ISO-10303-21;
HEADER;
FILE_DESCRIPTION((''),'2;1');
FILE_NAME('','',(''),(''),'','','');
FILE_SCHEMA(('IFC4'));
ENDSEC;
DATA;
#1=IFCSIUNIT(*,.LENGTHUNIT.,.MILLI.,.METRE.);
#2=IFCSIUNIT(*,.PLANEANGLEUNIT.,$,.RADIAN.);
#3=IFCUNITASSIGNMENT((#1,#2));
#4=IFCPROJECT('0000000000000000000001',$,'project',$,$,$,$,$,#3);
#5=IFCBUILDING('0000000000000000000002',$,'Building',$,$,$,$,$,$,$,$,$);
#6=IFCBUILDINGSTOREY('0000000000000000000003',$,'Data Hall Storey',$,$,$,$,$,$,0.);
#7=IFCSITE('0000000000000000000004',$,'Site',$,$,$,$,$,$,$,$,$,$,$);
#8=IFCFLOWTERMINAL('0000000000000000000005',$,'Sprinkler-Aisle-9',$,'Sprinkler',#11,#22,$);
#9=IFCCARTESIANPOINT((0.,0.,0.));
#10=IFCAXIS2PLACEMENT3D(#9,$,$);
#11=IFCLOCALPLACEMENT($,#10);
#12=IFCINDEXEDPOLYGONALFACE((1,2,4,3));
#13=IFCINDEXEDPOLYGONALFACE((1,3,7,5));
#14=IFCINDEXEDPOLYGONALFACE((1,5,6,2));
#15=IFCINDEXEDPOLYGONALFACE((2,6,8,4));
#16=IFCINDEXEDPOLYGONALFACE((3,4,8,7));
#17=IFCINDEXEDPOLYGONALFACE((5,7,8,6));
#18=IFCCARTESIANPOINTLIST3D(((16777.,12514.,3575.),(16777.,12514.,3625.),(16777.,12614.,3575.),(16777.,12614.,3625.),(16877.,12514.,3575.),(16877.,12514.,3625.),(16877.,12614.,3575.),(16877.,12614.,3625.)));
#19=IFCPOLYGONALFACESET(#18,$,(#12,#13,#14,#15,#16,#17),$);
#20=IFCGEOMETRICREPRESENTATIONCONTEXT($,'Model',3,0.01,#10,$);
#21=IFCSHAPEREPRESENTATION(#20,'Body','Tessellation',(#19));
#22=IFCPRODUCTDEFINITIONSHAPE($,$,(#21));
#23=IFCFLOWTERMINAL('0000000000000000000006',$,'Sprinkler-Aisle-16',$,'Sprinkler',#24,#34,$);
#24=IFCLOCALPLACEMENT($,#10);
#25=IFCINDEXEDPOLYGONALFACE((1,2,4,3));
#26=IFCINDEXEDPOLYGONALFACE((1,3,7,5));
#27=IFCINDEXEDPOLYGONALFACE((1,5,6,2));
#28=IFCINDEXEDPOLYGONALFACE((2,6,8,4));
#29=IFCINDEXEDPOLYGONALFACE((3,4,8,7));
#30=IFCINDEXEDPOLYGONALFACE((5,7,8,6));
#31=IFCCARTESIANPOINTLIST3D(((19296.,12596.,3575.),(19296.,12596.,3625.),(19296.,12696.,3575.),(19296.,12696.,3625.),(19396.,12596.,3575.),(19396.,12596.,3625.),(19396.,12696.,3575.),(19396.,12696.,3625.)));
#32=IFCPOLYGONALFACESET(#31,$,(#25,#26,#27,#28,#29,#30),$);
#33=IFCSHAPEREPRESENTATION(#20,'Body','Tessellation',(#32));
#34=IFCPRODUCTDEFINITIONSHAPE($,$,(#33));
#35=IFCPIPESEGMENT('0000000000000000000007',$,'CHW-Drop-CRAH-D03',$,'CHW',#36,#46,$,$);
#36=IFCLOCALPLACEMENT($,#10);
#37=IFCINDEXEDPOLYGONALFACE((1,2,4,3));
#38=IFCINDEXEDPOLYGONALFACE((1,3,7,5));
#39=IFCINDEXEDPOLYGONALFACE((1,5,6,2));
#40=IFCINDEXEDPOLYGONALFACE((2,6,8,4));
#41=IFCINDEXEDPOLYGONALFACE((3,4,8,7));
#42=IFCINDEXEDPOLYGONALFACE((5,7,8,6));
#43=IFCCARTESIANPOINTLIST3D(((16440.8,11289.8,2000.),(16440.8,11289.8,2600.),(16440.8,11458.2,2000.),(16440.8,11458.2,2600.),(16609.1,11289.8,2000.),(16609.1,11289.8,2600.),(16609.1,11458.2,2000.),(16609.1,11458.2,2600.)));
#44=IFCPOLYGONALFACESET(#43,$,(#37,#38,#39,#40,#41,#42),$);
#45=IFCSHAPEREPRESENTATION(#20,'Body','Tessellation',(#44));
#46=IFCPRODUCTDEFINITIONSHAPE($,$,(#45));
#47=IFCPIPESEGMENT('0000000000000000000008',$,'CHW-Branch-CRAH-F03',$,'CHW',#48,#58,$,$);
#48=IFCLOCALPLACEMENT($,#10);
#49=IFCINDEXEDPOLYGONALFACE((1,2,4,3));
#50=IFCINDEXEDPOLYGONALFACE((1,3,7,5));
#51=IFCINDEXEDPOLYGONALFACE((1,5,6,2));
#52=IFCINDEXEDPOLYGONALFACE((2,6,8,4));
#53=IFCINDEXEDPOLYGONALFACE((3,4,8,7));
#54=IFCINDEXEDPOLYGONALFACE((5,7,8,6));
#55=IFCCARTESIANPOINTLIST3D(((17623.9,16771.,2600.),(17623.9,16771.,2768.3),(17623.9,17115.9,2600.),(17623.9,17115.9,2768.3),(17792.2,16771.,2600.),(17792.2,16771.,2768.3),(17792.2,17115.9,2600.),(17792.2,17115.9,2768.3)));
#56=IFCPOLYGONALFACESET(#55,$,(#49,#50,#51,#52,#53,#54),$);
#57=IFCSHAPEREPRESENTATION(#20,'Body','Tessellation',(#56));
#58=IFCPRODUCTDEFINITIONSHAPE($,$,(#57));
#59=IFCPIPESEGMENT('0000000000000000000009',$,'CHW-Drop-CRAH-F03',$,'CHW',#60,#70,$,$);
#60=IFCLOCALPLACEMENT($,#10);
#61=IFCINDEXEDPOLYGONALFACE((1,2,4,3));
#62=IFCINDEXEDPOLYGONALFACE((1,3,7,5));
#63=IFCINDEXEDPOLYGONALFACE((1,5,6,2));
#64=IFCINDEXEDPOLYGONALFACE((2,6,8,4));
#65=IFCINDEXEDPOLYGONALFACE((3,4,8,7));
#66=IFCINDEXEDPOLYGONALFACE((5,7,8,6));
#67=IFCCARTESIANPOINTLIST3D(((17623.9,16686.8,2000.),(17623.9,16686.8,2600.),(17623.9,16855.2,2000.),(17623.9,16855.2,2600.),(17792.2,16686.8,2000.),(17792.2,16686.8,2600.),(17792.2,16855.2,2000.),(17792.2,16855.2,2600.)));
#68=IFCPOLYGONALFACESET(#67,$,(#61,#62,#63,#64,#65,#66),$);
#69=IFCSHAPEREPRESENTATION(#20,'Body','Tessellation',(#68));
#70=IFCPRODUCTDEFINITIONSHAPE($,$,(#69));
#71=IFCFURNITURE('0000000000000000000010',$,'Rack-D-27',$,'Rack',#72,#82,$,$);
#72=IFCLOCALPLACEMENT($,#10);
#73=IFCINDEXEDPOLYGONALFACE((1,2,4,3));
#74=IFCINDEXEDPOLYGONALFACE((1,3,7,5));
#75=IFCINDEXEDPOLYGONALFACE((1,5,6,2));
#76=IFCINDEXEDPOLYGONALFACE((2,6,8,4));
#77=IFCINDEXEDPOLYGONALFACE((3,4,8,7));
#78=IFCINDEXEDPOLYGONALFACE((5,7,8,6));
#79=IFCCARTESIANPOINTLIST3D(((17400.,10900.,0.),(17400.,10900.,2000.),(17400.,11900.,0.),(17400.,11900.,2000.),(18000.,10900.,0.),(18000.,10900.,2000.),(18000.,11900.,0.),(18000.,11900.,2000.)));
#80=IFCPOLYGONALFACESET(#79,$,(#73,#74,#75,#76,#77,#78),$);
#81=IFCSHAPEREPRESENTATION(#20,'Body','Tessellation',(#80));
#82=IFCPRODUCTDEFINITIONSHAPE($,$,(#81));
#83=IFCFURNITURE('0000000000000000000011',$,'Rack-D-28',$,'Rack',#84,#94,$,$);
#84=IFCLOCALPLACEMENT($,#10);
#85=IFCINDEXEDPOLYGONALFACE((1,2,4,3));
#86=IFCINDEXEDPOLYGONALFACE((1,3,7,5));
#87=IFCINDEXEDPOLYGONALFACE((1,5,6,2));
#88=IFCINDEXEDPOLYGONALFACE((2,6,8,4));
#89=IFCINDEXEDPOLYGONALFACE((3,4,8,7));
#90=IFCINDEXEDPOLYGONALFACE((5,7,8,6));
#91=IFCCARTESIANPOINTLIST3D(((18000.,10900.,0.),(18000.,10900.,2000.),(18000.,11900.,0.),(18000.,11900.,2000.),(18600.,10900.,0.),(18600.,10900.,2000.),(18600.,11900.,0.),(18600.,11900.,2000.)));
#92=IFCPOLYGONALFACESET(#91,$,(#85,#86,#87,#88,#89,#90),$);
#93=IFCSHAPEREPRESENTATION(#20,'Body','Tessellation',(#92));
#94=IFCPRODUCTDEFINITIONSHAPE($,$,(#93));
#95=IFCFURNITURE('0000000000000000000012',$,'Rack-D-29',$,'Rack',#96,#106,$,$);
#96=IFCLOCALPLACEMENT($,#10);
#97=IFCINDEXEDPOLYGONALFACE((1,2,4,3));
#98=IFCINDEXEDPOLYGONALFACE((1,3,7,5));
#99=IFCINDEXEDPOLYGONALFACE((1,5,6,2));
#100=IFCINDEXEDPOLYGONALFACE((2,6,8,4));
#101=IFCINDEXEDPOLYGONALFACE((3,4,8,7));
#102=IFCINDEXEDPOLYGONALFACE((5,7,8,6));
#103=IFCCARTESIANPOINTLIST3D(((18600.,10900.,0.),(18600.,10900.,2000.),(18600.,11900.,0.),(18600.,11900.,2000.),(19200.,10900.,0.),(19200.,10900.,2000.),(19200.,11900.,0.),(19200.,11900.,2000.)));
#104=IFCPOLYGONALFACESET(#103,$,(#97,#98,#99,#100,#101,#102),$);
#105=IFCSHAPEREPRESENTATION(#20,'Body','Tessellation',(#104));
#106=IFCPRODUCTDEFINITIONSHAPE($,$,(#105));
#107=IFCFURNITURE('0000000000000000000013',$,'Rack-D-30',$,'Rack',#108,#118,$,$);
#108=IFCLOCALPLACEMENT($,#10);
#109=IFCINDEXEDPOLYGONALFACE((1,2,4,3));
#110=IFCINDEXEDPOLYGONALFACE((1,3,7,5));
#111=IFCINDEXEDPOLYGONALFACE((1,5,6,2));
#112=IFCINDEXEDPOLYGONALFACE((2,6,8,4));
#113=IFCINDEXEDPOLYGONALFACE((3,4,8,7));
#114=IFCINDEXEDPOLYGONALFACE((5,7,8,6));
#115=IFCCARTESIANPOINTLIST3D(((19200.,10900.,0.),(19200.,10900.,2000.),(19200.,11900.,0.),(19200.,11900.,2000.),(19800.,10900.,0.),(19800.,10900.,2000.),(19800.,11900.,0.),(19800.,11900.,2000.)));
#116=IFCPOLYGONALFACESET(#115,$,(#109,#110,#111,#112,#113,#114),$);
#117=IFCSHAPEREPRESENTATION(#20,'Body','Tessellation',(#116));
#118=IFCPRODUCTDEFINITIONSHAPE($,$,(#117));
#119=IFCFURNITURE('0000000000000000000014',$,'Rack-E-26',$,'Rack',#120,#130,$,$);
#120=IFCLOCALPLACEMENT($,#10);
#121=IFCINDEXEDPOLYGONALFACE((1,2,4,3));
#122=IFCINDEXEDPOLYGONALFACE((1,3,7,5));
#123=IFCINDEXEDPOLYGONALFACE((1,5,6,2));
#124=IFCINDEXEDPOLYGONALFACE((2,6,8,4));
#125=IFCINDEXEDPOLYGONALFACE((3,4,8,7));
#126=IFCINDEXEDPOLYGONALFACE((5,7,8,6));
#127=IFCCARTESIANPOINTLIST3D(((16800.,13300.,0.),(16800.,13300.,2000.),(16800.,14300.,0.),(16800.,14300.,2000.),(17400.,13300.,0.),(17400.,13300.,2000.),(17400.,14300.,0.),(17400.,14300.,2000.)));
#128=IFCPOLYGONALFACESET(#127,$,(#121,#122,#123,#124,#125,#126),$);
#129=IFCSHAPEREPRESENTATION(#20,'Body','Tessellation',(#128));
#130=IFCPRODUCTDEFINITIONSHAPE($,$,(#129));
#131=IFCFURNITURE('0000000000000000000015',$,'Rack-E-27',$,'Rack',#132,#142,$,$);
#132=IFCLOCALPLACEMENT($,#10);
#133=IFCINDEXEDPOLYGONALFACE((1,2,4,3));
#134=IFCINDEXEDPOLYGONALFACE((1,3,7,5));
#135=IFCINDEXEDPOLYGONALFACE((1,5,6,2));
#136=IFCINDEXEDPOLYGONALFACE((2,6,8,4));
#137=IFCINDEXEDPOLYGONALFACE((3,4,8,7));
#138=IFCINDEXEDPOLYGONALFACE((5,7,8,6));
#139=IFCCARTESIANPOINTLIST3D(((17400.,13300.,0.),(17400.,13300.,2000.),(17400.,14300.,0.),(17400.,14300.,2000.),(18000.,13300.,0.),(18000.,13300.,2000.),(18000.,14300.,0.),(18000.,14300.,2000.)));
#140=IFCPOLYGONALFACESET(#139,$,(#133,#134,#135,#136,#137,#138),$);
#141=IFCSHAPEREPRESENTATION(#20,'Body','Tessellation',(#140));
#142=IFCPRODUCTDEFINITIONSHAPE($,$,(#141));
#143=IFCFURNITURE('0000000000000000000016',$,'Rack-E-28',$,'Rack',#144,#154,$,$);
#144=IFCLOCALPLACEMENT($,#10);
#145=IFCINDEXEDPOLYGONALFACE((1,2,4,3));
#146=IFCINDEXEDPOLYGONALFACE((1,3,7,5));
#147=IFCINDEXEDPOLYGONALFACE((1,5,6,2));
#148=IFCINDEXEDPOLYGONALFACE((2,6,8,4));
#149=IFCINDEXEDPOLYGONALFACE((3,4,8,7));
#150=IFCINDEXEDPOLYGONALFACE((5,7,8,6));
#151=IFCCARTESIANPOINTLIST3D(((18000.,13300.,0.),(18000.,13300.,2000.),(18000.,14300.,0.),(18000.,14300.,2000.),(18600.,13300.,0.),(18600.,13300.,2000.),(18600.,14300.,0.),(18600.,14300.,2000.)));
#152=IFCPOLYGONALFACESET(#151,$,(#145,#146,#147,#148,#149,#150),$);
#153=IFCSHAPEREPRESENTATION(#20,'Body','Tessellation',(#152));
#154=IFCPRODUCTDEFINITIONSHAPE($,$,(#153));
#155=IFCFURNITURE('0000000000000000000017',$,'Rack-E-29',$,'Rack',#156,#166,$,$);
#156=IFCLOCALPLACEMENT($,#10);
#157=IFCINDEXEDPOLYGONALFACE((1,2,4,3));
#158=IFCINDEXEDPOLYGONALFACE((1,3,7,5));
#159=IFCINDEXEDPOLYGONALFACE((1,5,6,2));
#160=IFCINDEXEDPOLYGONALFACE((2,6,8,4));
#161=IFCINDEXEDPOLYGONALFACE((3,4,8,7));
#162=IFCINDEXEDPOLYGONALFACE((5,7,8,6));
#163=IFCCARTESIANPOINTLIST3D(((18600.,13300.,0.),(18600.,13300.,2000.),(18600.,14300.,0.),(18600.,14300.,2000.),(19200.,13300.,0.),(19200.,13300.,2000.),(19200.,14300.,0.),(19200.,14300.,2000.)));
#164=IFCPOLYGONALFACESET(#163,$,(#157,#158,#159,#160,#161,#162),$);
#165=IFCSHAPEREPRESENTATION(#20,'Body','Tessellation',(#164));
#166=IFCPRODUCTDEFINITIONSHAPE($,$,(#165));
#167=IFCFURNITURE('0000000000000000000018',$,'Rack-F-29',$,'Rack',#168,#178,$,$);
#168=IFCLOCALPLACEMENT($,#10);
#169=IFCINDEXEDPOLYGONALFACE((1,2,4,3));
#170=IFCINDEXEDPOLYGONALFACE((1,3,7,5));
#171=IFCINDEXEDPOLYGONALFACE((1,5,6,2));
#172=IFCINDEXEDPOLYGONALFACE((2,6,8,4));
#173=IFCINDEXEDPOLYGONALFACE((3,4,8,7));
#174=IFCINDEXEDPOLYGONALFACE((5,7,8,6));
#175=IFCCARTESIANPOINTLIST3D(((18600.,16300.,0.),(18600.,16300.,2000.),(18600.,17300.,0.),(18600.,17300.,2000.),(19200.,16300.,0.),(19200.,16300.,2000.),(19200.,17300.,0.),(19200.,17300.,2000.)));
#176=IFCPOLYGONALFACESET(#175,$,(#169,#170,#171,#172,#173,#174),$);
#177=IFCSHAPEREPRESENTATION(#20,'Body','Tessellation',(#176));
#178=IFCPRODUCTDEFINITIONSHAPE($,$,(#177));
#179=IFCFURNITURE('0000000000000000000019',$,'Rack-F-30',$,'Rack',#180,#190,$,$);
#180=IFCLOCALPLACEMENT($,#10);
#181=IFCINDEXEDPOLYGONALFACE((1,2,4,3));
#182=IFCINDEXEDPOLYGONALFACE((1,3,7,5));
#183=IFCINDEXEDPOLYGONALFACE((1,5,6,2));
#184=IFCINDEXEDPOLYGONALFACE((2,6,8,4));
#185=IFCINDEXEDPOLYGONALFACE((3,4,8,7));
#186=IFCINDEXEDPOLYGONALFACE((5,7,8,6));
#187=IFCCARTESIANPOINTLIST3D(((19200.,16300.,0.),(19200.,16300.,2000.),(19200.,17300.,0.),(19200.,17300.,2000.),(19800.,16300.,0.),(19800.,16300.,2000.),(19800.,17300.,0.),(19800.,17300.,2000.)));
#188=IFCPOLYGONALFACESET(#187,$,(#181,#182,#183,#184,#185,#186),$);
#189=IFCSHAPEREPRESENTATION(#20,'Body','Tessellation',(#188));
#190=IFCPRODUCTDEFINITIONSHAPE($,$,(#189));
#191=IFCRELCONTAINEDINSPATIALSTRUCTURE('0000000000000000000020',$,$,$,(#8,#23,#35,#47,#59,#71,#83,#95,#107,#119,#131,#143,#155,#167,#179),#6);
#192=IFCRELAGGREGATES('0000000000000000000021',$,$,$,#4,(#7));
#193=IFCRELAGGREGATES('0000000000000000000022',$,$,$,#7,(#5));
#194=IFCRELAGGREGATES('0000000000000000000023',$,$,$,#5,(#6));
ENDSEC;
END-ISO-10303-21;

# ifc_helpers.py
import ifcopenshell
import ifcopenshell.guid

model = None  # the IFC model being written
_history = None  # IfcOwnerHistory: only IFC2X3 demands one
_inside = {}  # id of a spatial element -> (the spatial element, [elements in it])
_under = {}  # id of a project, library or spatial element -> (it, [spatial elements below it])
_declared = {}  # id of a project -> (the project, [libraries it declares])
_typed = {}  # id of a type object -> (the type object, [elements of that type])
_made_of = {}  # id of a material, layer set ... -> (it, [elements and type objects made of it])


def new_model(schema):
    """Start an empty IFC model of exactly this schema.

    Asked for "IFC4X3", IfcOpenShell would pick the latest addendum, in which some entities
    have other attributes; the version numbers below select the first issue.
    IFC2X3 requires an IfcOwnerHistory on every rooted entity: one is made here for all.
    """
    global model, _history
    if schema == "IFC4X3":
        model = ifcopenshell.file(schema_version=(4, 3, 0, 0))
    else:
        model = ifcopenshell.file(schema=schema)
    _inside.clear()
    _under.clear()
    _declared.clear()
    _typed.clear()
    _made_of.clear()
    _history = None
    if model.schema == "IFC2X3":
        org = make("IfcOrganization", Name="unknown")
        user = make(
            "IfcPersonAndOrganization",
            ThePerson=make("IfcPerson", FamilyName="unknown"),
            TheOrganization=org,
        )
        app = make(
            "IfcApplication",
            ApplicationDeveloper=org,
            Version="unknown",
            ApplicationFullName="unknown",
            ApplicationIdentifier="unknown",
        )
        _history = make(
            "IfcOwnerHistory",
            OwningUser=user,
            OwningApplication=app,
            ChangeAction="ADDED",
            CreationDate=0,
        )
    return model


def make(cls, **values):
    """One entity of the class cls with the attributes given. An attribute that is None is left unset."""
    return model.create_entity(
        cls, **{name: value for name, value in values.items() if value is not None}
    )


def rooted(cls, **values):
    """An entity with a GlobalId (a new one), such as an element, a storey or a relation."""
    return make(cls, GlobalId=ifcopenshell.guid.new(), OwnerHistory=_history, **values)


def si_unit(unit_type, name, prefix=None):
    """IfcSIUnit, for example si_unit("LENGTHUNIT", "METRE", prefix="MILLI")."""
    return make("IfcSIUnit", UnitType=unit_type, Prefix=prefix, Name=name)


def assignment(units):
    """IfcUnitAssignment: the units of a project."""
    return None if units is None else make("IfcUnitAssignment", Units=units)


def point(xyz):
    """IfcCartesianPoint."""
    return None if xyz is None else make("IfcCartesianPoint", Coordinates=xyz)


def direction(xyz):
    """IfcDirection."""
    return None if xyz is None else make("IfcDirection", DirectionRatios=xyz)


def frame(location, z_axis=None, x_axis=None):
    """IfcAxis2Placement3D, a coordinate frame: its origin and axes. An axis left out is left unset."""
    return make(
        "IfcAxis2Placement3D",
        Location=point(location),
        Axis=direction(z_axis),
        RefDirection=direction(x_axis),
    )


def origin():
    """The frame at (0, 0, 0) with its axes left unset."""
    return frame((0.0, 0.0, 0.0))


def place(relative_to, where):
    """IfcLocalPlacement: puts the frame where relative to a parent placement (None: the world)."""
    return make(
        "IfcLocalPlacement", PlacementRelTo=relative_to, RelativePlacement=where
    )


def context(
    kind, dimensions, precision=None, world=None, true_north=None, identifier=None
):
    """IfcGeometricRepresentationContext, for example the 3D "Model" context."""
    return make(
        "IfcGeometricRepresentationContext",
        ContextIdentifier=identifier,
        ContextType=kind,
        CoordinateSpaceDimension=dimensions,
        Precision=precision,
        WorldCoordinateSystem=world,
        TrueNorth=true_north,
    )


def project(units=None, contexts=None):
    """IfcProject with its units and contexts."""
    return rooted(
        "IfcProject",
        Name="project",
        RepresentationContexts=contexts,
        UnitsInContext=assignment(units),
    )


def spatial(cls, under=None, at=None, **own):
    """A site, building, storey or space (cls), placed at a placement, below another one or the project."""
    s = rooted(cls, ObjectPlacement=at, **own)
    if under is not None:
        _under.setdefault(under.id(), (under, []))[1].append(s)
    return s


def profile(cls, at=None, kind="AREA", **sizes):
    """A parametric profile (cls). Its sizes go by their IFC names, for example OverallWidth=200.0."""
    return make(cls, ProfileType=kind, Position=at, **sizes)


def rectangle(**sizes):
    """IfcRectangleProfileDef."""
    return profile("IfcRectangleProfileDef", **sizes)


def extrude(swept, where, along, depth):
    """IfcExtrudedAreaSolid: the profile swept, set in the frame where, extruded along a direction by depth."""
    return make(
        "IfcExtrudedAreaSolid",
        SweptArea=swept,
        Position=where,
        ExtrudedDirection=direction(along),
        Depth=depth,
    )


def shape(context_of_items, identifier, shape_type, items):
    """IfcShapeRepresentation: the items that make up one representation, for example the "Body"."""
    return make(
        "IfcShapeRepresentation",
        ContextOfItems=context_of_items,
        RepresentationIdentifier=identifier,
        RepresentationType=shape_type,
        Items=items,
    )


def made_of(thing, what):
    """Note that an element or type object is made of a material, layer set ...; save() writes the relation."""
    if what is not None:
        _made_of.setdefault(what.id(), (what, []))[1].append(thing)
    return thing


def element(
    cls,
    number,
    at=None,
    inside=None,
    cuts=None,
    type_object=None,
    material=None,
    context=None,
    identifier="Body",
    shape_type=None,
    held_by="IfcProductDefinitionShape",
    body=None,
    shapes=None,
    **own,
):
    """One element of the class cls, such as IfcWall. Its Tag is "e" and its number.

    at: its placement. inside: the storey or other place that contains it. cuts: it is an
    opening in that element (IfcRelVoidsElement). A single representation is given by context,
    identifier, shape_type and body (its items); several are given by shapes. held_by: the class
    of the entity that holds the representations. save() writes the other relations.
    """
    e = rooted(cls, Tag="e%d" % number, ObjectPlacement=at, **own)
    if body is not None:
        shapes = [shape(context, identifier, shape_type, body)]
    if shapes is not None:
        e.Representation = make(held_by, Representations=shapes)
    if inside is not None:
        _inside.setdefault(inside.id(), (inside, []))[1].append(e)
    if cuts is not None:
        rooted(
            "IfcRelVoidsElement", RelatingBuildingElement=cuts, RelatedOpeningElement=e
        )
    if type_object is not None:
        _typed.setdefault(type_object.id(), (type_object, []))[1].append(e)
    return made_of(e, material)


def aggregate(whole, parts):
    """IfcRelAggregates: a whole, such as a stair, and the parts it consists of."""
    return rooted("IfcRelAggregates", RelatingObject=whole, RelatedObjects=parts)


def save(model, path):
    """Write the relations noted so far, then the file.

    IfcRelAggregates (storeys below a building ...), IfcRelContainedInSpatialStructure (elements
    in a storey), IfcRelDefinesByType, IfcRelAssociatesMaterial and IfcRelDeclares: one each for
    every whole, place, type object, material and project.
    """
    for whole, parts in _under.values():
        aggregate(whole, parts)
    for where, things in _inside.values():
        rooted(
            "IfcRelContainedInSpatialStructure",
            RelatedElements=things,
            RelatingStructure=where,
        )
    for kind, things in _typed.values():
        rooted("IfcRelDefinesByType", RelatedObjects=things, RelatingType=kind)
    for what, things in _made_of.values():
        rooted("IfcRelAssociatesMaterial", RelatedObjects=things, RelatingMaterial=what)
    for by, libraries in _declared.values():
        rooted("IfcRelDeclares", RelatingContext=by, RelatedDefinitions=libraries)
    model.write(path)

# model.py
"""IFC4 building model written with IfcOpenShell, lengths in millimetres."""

from ifc_helpers import new_model, si_unit, frame, origin, place, context, project, spatial, rectangle, extrude, element, save


model = new_model("IFC4")

# Units and contexts
model_context = context("Model", 3, precision=0.01, world=origin())
ifc_project = project(units=[si_unit("LENGTHUNIT", "METRE", prefix="MILLI"), si_unit("PLANEANGLEUNIT", "RADIAN")])

# Site, building, storey
site = spatial("IfcSite", under=ifc_project, Name="Site")
building = spatial("IfcBuilding", under=site, Name="Building")
storey = spatial("IfcBuildingStorey", under=building, Name="Data Hall Storey", Elevation=0.0)

# Flow terminals
for number, where, name in (
    (1, (16827.0, 12564.0, 3575.0), "Sprinkler-Aisle-9"),
    (2, (19346.0, 12646.0, 3575.0), "Sprinkler-Aisle-16"),
):
    element("IfcFlowTerminal", number, at=place(None, frame(where)), inside=storey, Name=name, ObjectType="Sprinkler", context=model_context, shape_type="SweptSolid", body=[
        extrude(rectangle(XDim=100.0, YDim=100.0), origin(), (0.0, 0.0, 1.0), 50.0),
    ])

# Pipe segments
pipe_segment_1_placement = place(None, frame((16525.0, 11374.0, 2000.0)))
element("IfcPipeSegment", 3, at=pipe_segment_1_placement, inside=storey, Name="CHW-Drop-CRAH-D03", ObjectType="CHW", context=model_context, shape_type="SweptSolid", body=[
    extrude(rectangle(XDim=168.3, YDim=168.3), origin(), (0.0, 0.0, 1.0), 600.0),
])
pipe_segment_2_placement = place(None, frame((17708.0, 16943.4, 2600.0)))
element("IfcPipeSegment", 4, at=pipe_segment_2_placement, inside=storey, Name="CHW-Branch-CRAH-F03", ObjectType="CHW", context=model_context, shape_type="SweptSolid", body=[
    extrude(rectangle(XDim=168.3, YDim=344.8), origin(), (0.0, 0.0, 1.0), 168.3),
])
pipe_segment_3_placement = place(None, frame((17708.0, 16771.0, 2000.0)))
element("IfcPipeSegment", 5, at=pipe_segment_3_placement, inside=storey, Name="CHW-Drop-CRAH-F03", ObjectType="CHW", context=model_context, shape_type="SweptSolid", body=[
    extrude(rectangle(XDim=168.3, YDim=168.3), origin(), (0.0, 0.0, 1.0), 600.0),
])

# Furniture
for number, where, name in (
    (6, (17700.0, 11400.0, 0.0), "Rack-D-27"),
    (7, (18300.0, 11400.0, 0.0), "Rack-D-28"),
    (8, (18900.0, 11400.0, 0.0), "Rack-D-29"),
    (9, (19500.0, 11400.0, 0.0), "Rack-D-30"),
    (10, (17100.0, 13800.0, 0.0), "Rack-E-26"),
    (11, (17700.0, 13800.0, 0.0), "Rack-E-27"),
    (12, (18300.0, 13800.0, 0.0), "Rack-E-28"),
    (13, (18900.0, 13800.0, 0.0), "Rack-E-29"),
    (14, (18900.0, 16800.0, 0.0), "Rack-F-29"),
    (15, (19500.0, 16800.0, 0.0), "Rack-F-30"),
):
    element("IfcFurniture", number, at=place(None, frame(where)), inside=storey, Name=name, ObjectType="Rack", context=model_context, shape_type="SweptSolid", body=[
        extrude(rectangle(XDim=600.0, YDim=1000.0), origin(), (0.0, 0.0, 1.0), 2000.0),
    ])

save(model, "model.ifc")
